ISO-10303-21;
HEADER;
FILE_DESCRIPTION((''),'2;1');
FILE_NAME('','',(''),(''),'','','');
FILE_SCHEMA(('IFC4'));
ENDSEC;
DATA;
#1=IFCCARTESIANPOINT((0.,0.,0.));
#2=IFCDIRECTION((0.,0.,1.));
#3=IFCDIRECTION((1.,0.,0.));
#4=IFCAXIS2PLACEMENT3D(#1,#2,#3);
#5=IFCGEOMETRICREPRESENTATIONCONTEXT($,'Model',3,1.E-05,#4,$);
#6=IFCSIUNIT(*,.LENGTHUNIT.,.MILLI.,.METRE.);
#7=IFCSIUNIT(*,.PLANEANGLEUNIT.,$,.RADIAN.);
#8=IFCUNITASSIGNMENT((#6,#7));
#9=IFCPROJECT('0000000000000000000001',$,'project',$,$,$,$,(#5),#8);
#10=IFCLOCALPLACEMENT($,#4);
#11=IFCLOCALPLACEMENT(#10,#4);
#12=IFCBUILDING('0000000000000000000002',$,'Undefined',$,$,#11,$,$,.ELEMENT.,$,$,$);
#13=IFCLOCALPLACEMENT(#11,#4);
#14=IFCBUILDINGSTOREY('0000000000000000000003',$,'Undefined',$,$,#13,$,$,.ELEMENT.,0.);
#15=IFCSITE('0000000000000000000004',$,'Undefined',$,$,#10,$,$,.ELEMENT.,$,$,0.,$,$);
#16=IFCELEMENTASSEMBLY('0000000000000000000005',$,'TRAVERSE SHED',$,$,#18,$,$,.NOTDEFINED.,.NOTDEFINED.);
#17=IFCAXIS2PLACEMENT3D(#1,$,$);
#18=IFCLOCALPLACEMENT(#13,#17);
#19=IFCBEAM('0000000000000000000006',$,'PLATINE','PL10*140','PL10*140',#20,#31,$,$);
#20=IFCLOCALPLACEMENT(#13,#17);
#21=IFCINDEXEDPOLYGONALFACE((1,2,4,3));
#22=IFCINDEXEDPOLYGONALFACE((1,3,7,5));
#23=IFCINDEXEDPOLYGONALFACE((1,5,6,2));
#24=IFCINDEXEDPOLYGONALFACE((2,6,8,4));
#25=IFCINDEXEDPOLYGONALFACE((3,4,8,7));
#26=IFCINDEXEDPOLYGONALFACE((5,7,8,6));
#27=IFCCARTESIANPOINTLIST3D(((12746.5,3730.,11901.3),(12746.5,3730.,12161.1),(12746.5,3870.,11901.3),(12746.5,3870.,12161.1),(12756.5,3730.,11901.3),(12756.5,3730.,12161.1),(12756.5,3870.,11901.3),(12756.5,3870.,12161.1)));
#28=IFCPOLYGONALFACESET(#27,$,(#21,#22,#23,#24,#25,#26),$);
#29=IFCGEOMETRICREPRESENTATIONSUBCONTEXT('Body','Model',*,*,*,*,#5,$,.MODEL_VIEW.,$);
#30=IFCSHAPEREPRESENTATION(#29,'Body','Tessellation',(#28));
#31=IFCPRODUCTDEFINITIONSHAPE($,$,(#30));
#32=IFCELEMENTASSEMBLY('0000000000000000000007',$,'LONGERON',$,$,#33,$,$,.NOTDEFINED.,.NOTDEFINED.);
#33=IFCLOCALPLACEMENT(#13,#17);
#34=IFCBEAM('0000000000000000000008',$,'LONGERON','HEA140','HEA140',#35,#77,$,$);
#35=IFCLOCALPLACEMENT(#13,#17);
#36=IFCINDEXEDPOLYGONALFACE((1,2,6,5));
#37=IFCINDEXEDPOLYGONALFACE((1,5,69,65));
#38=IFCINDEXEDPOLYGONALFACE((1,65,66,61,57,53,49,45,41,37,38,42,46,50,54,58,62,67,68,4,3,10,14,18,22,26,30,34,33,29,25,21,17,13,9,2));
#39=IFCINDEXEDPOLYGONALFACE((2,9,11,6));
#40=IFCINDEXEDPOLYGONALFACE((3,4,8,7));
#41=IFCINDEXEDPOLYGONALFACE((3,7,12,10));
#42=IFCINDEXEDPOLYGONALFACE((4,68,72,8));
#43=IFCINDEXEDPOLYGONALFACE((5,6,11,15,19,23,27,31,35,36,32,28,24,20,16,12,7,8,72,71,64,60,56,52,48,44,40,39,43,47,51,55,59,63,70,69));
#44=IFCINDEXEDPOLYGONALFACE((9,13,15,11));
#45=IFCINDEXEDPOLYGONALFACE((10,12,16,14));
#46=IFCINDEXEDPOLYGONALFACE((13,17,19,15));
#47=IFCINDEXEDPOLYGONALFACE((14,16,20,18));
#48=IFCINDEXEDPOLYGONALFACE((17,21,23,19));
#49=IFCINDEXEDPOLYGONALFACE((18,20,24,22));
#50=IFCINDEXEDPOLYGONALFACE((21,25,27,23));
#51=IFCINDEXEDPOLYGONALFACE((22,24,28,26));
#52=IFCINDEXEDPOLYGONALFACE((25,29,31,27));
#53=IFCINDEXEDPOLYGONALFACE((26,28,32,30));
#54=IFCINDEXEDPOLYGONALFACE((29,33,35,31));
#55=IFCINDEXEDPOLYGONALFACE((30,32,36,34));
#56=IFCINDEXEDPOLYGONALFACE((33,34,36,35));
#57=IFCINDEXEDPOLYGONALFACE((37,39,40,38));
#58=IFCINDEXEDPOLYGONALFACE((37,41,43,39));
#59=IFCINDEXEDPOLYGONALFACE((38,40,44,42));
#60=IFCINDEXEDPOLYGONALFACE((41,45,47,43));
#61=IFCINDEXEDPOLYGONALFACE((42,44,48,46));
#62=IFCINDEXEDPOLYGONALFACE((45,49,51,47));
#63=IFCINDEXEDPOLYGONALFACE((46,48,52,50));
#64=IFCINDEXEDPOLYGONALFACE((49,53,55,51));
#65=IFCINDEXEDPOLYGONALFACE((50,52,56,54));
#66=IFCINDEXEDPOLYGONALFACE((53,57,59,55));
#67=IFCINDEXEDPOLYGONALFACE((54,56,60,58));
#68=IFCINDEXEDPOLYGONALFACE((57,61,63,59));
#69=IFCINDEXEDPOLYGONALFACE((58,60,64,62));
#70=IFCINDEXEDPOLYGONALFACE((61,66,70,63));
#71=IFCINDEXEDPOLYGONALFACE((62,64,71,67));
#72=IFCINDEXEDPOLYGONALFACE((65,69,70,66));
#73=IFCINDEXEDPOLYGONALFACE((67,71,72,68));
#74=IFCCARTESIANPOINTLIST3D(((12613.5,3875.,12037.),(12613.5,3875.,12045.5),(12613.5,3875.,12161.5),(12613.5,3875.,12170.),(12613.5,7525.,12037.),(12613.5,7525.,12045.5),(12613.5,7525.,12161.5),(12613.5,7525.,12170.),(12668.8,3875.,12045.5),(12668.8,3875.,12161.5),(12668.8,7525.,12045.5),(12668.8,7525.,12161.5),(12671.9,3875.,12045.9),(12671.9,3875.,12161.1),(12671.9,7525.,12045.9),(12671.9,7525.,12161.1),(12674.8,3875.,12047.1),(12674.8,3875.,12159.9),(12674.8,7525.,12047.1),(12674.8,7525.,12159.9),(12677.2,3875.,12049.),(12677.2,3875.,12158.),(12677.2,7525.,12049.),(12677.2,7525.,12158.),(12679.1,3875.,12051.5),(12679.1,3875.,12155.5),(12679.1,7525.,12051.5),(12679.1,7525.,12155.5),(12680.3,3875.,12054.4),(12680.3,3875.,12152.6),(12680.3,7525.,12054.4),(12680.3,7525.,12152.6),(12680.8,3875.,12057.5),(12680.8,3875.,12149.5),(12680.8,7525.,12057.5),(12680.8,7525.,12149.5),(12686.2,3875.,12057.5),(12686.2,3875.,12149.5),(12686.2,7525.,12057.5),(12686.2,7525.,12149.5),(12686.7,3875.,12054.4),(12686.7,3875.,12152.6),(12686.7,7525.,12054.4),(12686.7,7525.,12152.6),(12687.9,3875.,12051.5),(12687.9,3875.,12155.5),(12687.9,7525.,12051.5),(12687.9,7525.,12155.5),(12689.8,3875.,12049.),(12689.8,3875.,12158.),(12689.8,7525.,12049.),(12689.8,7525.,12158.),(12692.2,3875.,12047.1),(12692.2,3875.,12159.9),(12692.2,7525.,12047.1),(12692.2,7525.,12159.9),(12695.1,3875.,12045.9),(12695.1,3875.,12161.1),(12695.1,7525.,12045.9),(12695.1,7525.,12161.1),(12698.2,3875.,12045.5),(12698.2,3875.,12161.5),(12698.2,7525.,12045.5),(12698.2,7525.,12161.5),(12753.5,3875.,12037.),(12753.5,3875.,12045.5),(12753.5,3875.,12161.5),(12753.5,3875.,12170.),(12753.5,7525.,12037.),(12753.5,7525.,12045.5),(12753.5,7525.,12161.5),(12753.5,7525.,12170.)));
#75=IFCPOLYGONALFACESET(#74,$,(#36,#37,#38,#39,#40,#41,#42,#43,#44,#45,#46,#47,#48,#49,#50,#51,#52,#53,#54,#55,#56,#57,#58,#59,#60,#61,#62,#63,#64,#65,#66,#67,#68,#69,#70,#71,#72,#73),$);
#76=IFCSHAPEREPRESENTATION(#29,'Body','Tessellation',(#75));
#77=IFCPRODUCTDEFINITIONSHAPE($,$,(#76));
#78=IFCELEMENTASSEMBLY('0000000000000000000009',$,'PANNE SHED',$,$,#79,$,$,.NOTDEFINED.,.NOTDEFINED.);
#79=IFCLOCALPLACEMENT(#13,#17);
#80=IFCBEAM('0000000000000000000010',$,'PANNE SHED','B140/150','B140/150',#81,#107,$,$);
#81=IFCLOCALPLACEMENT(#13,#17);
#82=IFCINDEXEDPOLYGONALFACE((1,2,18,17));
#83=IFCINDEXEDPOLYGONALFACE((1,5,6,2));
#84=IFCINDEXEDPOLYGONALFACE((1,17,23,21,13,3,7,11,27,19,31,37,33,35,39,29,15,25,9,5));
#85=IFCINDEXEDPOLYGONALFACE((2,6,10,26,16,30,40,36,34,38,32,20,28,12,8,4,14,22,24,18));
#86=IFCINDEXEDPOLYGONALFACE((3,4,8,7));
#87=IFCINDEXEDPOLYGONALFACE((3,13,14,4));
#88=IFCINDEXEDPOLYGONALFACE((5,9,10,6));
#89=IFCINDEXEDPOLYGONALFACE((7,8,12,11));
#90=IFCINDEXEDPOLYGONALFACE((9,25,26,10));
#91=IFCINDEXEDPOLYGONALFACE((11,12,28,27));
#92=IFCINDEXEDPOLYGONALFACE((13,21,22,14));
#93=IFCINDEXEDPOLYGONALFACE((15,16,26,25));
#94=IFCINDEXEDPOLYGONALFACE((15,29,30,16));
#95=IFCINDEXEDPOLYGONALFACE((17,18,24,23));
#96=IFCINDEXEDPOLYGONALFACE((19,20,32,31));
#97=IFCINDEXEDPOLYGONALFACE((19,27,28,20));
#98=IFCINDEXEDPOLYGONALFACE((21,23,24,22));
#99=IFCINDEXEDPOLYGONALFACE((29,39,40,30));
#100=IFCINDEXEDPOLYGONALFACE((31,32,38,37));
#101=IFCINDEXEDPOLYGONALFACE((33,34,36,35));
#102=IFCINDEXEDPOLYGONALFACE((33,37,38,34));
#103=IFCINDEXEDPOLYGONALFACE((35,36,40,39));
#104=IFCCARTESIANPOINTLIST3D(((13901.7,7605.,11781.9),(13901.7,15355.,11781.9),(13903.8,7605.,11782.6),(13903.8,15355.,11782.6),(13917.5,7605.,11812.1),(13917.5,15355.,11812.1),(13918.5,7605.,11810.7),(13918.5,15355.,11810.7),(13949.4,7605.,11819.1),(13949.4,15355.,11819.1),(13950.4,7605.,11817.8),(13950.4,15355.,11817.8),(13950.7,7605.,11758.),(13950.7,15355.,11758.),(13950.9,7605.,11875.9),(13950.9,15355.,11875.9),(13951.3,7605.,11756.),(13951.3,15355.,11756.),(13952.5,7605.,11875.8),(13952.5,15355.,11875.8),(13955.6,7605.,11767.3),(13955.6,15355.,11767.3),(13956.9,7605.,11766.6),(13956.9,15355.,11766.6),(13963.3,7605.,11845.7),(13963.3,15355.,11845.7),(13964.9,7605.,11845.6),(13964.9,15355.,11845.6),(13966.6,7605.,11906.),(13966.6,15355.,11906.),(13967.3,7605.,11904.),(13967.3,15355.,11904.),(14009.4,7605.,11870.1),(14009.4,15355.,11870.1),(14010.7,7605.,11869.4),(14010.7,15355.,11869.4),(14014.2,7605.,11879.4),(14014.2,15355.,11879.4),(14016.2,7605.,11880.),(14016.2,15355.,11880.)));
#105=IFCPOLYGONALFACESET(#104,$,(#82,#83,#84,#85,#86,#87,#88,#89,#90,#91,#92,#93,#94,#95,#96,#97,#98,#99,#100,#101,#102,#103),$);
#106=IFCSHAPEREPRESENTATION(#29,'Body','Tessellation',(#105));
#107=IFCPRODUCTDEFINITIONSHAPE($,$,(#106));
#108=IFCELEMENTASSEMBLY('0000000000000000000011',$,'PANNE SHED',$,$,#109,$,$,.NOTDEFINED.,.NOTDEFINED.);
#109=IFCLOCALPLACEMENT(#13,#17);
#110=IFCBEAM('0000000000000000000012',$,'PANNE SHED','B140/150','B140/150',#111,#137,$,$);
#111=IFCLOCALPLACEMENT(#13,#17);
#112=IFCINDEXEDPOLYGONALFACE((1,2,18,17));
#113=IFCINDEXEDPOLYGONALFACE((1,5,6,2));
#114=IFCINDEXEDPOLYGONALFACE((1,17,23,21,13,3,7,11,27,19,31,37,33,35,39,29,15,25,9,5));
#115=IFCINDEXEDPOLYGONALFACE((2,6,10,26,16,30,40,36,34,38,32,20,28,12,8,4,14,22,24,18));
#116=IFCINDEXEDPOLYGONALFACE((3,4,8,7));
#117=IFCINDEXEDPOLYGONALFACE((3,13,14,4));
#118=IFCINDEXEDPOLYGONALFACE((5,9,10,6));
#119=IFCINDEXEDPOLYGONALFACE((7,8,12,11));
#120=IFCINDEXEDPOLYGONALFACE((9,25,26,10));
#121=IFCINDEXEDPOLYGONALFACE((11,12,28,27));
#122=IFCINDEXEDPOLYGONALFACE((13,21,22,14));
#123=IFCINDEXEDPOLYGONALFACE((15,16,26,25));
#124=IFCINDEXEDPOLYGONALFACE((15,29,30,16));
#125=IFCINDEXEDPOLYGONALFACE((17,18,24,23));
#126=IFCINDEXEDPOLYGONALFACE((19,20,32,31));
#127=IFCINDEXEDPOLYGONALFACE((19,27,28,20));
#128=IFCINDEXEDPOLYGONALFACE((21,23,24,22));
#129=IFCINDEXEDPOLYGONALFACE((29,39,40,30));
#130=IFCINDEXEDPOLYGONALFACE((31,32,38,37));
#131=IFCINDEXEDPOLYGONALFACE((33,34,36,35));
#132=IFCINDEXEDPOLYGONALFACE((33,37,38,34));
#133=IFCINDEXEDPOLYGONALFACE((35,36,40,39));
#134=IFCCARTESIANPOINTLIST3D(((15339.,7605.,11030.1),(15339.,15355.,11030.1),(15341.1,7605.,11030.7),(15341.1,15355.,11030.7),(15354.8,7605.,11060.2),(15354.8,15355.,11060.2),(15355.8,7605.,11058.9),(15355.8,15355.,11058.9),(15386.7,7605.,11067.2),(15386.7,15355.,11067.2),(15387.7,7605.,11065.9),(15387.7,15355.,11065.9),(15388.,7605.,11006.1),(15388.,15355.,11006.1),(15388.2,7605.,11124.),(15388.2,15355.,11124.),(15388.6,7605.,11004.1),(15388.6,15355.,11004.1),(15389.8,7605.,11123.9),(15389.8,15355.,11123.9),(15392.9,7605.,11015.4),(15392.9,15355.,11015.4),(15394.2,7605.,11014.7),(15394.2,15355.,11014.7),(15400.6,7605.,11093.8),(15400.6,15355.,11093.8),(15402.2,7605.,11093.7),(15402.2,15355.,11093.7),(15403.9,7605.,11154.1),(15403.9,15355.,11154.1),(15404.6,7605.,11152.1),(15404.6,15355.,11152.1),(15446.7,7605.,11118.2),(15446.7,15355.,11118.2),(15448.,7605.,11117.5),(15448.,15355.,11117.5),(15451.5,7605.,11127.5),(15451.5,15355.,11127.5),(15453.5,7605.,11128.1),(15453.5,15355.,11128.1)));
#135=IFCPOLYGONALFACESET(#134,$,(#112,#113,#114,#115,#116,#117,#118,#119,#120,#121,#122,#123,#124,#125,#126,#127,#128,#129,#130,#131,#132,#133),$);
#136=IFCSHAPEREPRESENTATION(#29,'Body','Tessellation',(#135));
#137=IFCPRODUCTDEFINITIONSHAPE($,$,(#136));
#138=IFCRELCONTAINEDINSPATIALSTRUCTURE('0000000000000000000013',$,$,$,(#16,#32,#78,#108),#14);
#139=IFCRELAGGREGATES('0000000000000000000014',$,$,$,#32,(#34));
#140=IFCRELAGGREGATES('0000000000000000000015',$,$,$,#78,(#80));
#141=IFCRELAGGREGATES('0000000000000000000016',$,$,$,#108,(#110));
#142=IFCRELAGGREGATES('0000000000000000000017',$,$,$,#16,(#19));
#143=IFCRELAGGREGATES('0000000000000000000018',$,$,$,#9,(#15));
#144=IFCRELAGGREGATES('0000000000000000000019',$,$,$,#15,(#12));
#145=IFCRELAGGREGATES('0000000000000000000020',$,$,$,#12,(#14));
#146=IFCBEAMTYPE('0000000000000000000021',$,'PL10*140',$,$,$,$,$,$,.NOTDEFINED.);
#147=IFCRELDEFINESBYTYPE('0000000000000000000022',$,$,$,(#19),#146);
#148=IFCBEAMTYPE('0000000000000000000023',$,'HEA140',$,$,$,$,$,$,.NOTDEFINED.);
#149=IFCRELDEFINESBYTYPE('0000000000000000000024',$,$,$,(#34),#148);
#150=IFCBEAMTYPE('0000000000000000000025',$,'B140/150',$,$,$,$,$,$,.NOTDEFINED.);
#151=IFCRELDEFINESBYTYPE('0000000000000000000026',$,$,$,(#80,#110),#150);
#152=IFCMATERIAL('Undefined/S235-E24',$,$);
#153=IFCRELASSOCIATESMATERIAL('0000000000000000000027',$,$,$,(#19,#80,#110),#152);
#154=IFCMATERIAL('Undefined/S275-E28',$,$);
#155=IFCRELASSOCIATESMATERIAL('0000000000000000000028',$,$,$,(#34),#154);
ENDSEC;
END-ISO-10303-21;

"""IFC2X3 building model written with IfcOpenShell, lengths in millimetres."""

from ifc_helpers import new_model, si_unit, frame, origin_with_axes, origin_2d_with_axis, place, context, subcontext, project, spatial, polyline, rectangle, i_section, outline, extrude, material, type_object, element, aggregate, save


model = new_model("IFC2X3")

# Units and contexts
model_context = context("Model", 3, precision=1e-05, world=origin_with_axes())
body_context = subcontext(model_context, "Body", "Model", "MODEL_VIEW")
ifc_project = project(units=[si_unit("LENGTHUNIT", "METRE", prefix="MILLI"), si_unit("PLANEANGLEUNIT", "RADIAN")], contexts=[model_context])

# Site, building, storey
site_placement = place(None, origin_with_axes())
site = spatial("IfcSite", under=ifc_project, at=site_placement, Name="Undefined", CompositionType="ELEMENT", RefElevation=0.0)
building_placement = place(site_placement, origin_with_axes())
building = spatial("IfcBuilding", under=site, at=building_placement, Name="Undefined", CompositionType="ELEMENT")
storey_placement = place(building_placement, origin_with_axes())
storey = spatial("IfcBuildingStorey", under=building, at=storey_placement, Name="Undefined", CompositionType="ELEMENT", Elevation=0.0)

# Shared definitions
ifc_material_1 = material(Name="Undefined/S235-E24")

# Element assemblies, beams
beam_type_1 = type_object("IfcBeamType", Name="PL10*140", PredefinedType="NOTDEFINED")
assembly_1_placement = place(storey_placement, origin_with_axes())
assembly_1 = element("IfcElementAssembly", 1, at=assembly_1_placement, inside=storey, Name="TRAVERSE SHED", AssemblyPlace="NOTDEFINED", PredefinedType="NOTDEFINED")
beam_1_placement = place(assembly_1_placement, frame((12751.5, 3800.0, 12161.1), z_axis=(0.0, -1.0, 0.0), x_axis=(0.0, 0.0, -1.0)))
beam_1 = element("IfcBeam", 2, at=beam_1_placement, type_object=beam_type_1, material=ifc_material_1, Name="PLATINE", Description="PL10*140", ObjectType="PL10*140", context=body_context, shape_type="SweptSolid", body=[
    extrude(rectangle(XDim=10.0, YDim=140.0, at=origin_2d_with_axis()), frame((259.8, 0.0, 0.0), z_axis=(-1.0, 0.0, 0.0), x_axis=(0.0, -1.0, 0.0)), (0.0, 0.0, 1.0), 259.8),
])
assembly_2_placement = place(storey_placement, origin_with_axes())
assembly_2 = element("IfcElementAssembly", 3, at=assembly_2_placement, inside=storey, Name="LONGERON", AssemblyPlace="NOTDEFINED", PredefinedType="NOTDEFINED")
ifc_material_2 = material(Name="Undefined/S275-E28")
beam_type_2 = type_object("IfcBeamType", Name="HEA140", PredefinedType="NOTDEFINED")
beam_2_placement = place(assembly_2_placement, frame((12683.5, 7525.0, 12103.5), z_axis=(0.0, 0.0, 1.0), x_axis=(0.0, -1.0, 0.0)))
beam_2 = element("IfcBeam", 4, at=beam_2_placement, type_object=beam_type_2, material=ifc_material_2, Name="LONGERON", Description="HEA140", ObjectType="HEA140", context=body_context, shape_type="SweptSolid", body=[
    extrude(i_section(OverallWidth=140.0, OverallDepth=133.0, WebThickness=5.5, FlangeThickness=8.5, FilletRadius=12.0, at=origin_2d_with_axis()), frame((3650.0, 0.0, 0.0), z_axis=(-1.0, 0.0, 0.0), x_axis=(0.0, -1.0, 0.0)), (0.0, 0.0, 1.0), 3650.0),
])
aggregate(assembly_2, [beam_2])
assembly_3_placement = place(storey_placement, origin_with_axes())
assembly_3 = element("IfcElementAssembly", 5, at=assembly_3_placement, inside=storey, Name="PANNE SHED", AssemblyPlace="NOTDEFINED", PredefinedType="NOTDEFINED")
beam_type_3 = type_object("IfcBeamType", Name="B140/150", PredefinedType="NOTDEFINED")
beam_3_placement = place(assembly_3_placement, frame((13959.0, 7605.0, 11831.0), z_axis=(0.463529, 0.0, 0.886082), x_axis=(0.0, 1.0, 0.0)))
beam_3 = element("IfcBeam", 6, at=beam_3_placement, type_object=beam_type_3, material=ifc_material_1, Name="PANNE SHED", Description="B140/150", ObjectType="B140/150", context=body_context, shape_type="SweptSolid", body=[
    extrude(outline(polyline([(-28.0, 36.0), (-28.0, 70.0), (28.0, 70.0), (28.0, 58.0), (26.5, 58.0), (26.5, 68.5), (-26.5, 68.5), (-26.5, 36.7), (-1.5, 15.7), (-1.5, -15.7), (-26.5, -36.7), (-26.5, -68.5), (26.5, -68.5), (26.5, -58.0), (28.0, -58.0), (28.0, -70.0), (-28.0, -70.0), (-28.0, -36.0), (-3.0, -15.0), (-3.0, 15.0), (-28.0, 36.0)])), frame((7750.0, 0.0, 0.0), z_axis=(-1.0, 0.0, 0.0), x_axis=(0.0, -1.0, 0.0)), (0.0, 0.0, 1.0), 7750.0),
])
aggregate(assembly_3, [beam_3])
assembly_4_placement = place(storey_placement, origin_with_axes())
assembly_4 = element("IfcElementAssembly", 7, at=assembly_4_placement, inside=storey, Name="PANNE SHED", AssemblyPlace="NOTDEFINED", PredefinedType="NOTDEFINED")
beam_4_placement = place(assembly_4_placement, frame((15396.3, 7605.0, 11079.1), z_axis=(0.463529, 0.0, 0.886082), x_axis=(0.0, 1.0, 0.0)))
beam_4 = element("IfcBeam", 8, at=beam_4_placement, type_object=beam_type_3, material=ifc_material_1, Name="PANNE SHED", Description="B140/150", ObjectType="B140/150", context=body_context, shape_type="SweptSolid", body=[
    extrude(outline(polyline([(-28.0, 36.0), (-28.0, 70.0), (28.0, 70.0), (28.0, 58.0), (26.5, 58.0), (26.5, 68.5), (-26.5, 68.5), (-26.5, 36.7), (-1.5, 15.7), (-1.5, -15.7), (-26.5, -36.7), (-26.5, -68.5), (26.5, -68.5), (26.5, -58.0), (28.0, -58.0), (28.0, -70.0), (-28.0, -70.0), (-28.0, -36.0), (-3.0, -15.0), (-3.0, 15.0), (-28.0, 36.0)])), frame((7750.0, 0.0, 0.0), z_axis=(-1.0, 0.0, 0.0), x_axis=(0.0, -1.0, 0.0)), (0.0, 0.0, 1.0), 7750.0),
])
aggregate(assembly_4, [beam_4])

aggregate(assembly_1, [beam_1])

save(model, "model.ifc")
